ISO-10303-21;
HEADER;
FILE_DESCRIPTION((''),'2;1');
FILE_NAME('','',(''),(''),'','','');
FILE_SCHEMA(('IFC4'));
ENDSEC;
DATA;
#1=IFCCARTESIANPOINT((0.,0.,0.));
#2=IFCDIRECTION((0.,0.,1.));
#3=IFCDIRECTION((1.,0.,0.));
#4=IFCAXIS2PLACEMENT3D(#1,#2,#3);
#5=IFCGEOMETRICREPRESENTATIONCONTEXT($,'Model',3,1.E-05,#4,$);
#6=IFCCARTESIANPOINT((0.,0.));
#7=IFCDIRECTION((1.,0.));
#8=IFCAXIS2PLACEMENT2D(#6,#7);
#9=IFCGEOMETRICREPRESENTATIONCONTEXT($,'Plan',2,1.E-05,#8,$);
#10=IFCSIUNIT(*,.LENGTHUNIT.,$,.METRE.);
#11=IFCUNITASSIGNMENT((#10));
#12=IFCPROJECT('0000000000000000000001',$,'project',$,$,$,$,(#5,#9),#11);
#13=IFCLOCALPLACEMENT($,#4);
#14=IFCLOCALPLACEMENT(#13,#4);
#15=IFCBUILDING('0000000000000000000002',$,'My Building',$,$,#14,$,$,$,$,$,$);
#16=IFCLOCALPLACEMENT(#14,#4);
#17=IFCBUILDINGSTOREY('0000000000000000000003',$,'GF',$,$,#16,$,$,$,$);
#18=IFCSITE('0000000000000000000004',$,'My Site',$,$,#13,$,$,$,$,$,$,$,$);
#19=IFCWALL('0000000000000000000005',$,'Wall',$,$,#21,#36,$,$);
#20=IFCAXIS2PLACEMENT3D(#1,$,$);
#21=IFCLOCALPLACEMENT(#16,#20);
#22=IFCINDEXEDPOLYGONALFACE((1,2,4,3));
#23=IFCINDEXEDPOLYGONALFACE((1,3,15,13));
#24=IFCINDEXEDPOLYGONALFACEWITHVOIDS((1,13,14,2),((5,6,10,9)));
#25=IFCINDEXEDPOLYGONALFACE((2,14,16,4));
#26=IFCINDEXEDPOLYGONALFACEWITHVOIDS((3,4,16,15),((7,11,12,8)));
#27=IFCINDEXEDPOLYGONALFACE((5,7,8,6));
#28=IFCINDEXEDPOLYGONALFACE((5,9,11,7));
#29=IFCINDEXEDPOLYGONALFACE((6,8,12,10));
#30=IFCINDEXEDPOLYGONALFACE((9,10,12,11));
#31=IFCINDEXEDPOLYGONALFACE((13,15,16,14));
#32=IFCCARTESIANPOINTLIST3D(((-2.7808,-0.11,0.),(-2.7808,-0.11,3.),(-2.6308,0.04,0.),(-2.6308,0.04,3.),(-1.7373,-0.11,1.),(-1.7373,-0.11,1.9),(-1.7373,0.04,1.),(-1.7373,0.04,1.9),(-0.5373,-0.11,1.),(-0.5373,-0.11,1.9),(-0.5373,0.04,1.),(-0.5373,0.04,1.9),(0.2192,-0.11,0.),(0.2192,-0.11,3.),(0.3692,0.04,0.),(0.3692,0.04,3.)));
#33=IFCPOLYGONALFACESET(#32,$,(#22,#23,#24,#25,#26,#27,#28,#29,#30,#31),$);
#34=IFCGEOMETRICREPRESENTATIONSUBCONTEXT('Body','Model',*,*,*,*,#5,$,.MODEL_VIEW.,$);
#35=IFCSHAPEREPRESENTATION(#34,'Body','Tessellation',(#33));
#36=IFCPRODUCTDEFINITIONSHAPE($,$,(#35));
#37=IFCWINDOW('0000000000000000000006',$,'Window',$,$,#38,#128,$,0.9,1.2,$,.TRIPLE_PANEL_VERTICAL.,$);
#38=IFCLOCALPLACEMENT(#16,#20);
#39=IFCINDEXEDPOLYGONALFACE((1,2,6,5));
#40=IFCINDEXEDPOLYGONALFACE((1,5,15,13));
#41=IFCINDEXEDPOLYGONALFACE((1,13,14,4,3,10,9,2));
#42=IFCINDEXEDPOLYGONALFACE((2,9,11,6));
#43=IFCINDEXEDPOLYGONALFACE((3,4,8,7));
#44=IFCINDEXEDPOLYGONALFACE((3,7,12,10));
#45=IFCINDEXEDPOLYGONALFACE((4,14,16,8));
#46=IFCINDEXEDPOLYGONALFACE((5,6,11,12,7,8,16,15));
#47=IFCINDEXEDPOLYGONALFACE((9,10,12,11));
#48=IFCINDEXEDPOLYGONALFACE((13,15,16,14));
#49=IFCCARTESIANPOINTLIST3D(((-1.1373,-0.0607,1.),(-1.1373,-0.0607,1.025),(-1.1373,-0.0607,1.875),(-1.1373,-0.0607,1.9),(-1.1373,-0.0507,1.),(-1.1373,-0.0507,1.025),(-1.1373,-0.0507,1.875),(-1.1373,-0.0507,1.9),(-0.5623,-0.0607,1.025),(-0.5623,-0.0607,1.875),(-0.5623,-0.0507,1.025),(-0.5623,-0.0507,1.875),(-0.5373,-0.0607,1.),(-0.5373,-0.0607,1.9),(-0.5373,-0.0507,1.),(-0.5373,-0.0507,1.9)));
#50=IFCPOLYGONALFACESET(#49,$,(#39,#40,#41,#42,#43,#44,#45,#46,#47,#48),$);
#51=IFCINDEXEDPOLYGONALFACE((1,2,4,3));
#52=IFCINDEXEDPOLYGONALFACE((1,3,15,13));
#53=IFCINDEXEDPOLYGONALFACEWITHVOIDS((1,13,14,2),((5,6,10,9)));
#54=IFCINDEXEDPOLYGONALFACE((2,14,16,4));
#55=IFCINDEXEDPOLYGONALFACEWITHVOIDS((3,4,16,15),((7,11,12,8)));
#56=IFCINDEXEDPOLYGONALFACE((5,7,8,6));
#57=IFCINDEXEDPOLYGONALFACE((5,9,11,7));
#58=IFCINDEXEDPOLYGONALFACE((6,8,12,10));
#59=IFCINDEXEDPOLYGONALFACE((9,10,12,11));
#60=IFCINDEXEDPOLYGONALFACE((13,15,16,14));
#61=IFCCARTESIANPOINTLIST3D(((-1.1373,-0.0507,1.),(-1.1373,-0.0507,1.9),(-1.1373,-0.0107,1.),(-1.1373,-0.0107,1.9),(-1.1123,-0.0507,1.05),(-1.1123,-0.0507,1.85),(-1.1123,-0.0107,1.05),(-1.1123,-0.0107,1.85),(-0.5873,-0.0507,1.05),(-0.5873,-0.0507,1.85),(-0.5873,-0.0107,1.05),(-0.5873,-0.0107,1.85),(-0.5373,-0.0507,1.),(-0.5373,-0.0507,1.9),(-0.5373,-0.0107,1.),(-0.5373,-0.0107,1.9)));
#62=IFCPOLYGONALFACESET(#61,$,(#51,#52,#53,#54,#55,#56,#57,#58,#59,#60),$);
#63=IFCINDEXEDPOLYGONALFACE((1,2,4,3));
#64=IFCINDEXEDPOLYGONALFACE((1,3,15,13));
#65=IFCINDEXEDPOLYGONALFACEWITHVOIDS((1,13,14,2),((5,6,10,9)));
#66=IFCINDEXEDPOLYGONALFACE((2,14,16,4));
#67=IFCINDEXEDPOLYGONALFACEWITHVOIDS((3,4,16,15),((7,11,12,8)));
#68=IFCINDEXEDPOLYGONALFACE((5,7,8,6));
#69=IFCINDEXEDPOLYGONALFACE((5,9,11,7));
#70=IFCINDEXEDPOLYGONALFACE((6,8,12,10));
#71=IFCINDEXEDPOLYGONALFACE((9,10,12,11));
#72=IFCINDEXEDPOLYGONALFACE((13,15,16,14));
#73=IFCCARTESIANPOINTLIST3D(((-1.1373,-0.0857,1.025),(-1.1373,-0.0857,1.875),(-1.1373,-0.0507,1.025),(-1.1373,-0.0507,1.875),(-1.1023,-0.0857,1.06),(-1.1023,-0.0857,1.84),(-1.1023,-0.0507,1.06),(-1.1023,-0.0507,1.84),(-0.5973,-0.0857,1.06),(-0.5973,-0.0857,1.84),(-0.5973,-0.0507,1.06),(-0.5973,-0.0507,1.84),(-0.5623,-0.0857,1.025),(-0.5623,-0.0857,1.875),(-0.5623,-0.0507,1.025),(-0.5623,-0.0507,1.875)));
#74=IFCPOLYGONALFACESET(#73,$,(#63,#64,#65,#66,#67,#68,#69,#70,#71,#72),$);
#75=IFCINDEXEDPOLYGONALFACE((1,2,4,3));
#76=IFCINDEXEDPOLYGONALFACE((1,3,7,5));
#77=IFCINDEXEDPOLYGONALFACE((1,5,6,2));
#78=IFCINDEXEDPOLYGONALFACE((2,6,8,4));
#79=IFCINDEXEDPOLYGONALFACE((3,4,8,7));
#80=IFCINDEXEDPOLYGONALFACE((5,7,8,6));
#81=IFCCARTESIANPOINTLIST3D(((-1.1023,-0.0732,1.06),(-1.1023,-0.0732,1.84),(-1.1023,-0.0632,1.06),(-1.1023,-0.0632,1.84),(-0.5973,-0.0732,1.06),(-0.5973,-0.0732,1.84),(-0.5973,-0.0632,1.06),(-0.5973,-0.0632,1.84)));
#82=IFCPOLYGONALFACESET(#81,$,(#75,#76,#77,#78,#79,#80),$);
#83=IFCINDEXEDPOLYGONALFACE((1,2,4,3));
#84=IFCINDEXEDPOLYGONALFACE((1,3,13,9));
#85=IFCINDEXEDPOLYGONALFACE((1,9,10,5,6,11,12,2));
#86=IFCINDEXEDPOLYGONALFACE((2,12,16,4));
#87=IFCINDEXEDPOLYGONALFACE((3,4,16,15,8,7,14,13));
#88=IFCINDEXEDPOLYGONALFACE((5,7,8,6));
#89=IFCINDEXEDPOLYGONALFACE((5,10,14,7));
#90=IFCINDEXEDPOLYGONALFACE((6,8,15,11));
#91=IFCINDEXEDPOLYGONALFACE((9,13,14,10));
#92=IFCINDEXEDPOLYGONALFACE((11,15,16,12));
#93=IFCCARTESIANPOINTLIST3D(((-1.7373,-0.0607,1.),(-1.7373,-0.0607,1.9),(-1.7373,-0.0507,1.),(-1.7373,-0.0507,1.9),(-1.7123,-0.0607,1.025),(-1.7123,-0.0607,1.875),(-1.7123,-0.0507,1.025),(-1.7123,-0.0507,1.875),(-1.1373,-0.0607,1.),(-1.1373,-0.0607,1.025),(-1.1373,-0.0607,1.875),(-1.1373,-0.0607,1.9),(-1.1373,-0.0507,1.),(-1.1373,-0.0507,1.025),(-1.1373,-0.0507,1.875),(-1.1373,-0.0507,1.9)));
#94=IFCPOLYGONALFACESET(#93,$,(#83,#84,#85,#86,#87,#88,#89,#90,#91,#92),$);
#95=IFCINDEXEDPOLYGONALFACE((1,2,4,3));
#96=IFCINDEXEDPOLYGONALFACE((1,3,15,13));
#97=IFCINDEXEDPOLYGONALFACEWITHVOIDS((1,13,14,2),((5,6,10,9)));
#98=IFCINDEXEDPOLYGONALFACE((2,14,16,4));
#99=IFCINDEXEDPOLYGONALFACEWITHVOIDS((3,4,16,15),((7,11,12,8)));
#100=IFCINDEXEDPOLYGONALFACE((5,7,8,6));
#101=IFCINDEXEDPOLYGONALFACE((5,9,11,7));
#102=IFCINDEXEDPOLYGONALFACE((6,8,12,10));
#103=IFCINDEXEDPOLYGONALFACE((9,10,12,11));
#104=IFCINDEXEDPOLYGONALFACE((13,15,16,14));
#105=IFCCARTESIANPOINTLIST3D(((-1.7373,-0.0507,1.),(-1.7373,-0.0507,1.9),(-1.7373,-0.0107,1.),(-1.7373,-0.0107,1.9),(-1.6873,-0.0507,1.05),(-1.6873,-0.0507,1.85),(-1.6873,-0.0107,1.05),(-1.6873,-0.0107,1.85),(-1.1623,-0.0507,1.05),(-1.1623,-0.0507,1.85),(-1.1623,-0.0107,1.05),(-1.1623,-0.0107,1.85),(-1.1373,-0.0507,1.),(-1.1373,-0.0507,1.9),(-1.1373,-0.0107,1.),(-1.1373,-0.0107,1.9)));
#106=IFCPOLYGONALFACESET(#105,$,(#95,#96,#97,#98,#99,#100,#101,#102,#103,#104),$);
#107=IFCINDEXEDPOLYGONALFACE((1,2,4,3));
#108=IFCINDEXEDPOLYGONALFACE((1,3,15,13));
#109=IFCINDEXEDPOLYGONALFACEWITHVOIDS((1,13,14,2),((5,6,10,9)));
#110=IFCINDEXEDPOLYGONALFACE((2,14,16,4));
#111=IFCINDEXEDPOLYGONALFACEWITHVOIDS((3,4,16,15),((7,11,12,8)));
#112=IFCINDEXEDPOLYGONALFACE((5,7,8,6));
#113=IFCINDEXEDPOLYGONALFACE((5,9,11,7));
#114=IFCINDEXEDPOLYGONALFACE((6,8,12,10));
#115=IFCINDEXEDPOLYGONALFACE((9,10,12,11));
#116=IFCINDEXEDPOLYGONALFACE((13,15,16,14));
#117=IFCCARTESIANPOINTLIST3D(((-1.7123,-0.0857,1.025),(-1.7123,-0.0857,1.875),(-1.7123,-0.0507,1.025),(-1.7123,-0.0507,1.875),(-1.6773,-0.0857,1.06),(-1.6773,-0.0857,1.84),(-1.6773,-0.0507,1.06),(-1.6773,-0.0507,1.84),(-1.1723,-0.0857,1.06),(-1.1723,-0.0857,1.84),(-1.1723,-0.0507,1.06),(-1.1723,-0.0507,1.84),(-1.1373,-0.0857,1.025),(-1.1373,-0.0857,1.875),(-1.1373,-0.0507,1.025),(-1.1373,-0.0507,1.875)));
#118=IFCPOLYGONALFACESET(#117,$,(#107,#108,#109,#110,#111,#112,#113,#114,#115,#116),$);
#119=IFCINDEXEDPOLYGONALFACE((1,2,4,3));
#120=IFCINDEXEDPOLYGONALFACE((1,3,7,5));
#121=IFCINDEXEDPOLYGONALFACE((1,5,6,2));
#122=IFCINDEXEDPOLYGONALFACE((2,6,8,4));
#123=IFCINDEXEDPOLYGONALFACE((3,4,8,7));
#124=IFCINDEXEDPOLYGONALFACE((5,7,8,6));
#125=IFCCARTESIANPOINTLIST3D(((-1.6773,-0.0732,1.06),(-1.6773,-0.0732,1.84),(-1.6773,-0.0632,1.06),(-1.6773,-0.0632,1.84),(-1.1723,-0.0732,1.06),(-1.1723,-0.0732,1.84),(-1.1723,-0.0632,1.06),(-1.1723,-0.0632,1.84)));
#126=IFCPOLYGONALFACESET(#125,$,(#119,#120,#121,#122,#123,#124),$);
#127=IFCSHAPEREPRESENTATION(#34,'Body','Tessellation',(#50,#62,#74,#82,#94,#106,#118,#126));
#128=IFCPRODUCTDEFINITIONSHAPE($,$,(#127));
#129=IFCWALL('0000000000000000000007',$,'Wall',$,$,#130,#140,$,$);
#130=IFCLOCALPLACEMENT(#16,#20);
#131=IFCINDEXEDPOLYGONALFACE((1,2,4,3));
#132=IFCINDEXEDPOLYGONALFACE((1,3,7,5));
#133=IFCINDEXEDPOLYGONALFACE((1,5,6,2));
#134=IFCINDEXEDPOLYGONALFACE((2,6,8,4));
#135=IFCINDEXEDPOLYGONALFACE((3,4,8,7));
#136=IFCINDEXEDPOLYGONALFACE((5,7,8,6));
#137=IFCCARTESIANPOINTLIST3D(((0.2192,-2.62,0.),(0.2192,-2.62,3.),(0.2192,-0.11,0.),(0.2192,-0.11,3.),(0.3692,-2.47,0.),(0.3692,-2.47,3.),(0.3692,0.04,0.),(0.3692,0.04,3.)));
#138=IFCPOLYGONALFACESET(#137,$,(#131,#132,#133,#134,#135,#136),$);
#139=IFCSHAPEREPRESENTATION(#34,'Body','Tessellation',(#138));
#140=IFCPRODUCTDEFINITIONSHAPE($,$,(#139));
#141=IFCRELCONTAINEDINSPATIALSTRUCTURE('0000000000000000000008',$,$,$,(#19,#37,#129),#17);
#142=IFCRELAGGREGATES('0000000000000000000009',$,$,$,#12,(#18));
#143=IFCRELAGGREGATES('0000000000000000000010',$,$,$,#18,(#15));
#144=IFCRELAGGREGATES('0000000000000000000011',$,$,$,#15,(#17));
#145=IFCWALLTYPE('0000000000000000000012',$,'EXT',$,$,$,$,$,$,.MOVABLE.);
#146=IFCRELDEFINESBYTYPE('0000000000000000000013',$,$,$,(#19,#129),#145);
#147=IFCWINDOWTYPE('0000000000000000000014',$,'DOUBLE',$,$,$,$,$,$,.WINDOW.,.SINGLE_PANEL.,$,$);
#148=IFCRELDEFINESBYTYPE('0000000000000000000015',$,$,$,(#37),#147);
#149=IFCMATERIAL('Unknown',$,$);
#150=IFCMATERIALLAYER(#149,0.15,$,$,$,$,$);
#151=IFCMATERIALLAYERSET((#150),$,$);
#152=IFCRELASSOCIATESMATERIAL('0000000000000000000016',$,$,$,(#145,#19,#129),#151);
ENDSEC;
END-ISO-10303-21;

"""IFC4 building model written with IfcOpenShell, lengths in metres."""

from ifc_helpers import new_model, entity, si_unit, frame, origin_with_axes, origin_2d_with_axis, place, context, subcontext, project, spatial, line, indexed_curve, outline, extrude, shape, source, transform, mapped, material, layer, layer_set, layer_usage, type_object, type_shapes, element, fill, save


model = new_model("IFC4")

# Units and contexts
model_context = context("Model", 3, precision=1e-05, world=origin_with_axes())
plan_context = context("Plan", 2, precision=1e-05, world=origin_2d_with_axis())
body_context_1 = subcontext(model_context, "Body", "Model", "MODEL_VIEW")
body_context_2 = subcontext(plan_context, "Body", "Plan", "PLAN_VIEW")
ifc_project = project(units=[si_unit("LENGTHUNIT", "METRE")], contexts=[model_context, plan_context])

# Site, building, storey
site_placement = place(None, origin_with_axes())
site = spatial("IfcSite", under=ifc_project, at=site_placement, Name="My Site")
building_placement = place(site_placement, origin_with_axes())
building = spatial("IfcBuilding", under=site, at=building_placement, Name="My Building")
storey_placement = place(building_placement, origin_with_axes())
storey = spatial("IfcBuildingStorey", under=building, at=storey_placement, Name="GF")

# Shared definitions
ifc_material = material(Name="Unknown")

# Shared definitions
ifc_layer_1 = layer(ifc_material, 0.15)
ifc_layer_set_1 = layer_set([ifc_layer_1])
wall_type_1 = type_object("IfcWallType", Name="EXT", PredefinedType="MOVABLE", material=ifc_layer_set_1)

# Wall, opening, window
ifc_layer_usage_1 = layer_usage(ifc_layer_set_1, "AXIS2", "POSITIVE", 0.0)
wall_1_placement = place(storey_placement, frame((-2.7808, -0.11, 0.0), z_axis=(0.0, 0.0, 1.0), x_axis=(1.0, 0.0, 0.0)))
wall_1 = element("IfcWall", 1, at=wall_1_placement, inside=storey, type_object=wall_type_1, material=ifc_layer_usage_1, Name="Wall", context=body_context_1, shape_type="SweptSolid", body=[
    extrude(outline(indexed_curve([(0.0, 0.0), (0.15, 0.15), (3.15, 0.15), (3.0, 0.0)], segments=[line(1, 2, 3, 4, 1)])), origin_with_axes(), (0.0, 0.0, 1.0), 3.0),
])
placement_1 = place(storey_placement, frame((-0.5373, 0.0393, 1.0), z_axis=(0.0, 0.0, 1.0), x_axis=(-1.0, 0.000001, 0.0)))
opening_1 = element("IfcOpeningElement", 2, at=placement_1, cuts=wall_1, PredefinedType="OPENING", context=body_context_1, shape_type="SweptSolid", body=[
    extrude(outline(indexed_curve([(0.0, 0.0), (1.2, 0.0), (1.2, 0.9), (0.0, 0.9)], segments=[line(1, 2, 3, 4, 1)])), frame((0.0, -0.6, 0.0), z_axis=(0.0, -1.0, 0.0), x_axis=(1.0, 0.0, 0.0)), (0.0, 0.0, -1.0), 1.2),
])
window_type_1 = type_object("IfcWindowType", Name="DOUBLE", PartitioningType="SINGLE_PANEL", PredefinedType="WINDOW")
shared_shape_1 = source(origin_with_axes(), body_context_1, "Body", "SweptSolid", [
    extrude(outline(indexed_curve([(0.6, 0.0), (0.0, 0.0), (0.0, 0.9), (0.6, 0.9), (0.6, 0.875), (0.025, 0.875), (0.025, 0.025), (0.6, 0.025)], segments=[line(1, 2, 3, 4, 5, 6, 7, 8, 1)])), frame((0.0, 0.09, 0.0), z_axis=(0.0, -1.0, 0.0), x_axis=(1.0, 0.0, 0.0)), (0.0, 0.0, -1.0), 0.01),
    extrude(outline(indexed_curve([(0.0, 0.0), (0.6, 0.0), (0.6, 0.9), (0.0, 0.9)], segments=[line(1, 2, 3, 4, 1)]), holes=[indexed_curve([(0.05, 0.05), (0.575, 0.05), (0.575, 0.85), (0.05, 0.85)], segments=[line(1, 2, 3, 4, 1)])]), frame((0.0, 0.05, 0.0), z_axis=(0.0, -1.0, 0.0), x_axis=(1.0, 0.0, 0.0)), (0.0, 0.0, -1.0), 0.04),
    extrude(outline(indexed_curve([(0.0, 0.0), (0.575, 0.0), (0.575, 0.85), (0.0, 0.85)], segments=[line(1, 2, 3, 4, 1)]), holes=[indexed_curve([(0.035, 0.035), (0.54, 0.035), (0.54, 0.815), (0.035, 0.815)], segments=[line(1, 2, 3, 4, 1)])]), frame((0.025, 0.09, 0.025), z_axis=(0.0, -1.0, 0.0), x_axis=(1.0, 0.0, 0.0)), (0.0, 0.0, -1.0), 0.035),
    extrude(outline(indexed_curve([(0.035, 0.035), (0.54, 0.035), (0.54, 0.815), (0.035, 0.815)], segments=[line(1, 2, 3, 4, 1)])), frame((0.025, 0.1025, 0.025), z_axis=(0.0, -1.0, 0.0), x_axis=(1.0, 0.0, 0.0)), (0.0, 0.0, -1.0), 0.01),
    extrude(outline(indexed_curve([(0.0, 0.9), (0.6, 0.9), (0.6, 0.0), (0.0, 0.0), (0.0, 0.025), (0.575, 0.025), (0.575, 0.875), (0.0, 0.875)], segments=[line(1, 2, 3, 4, 5, 6, 7, 8, 1)])), frame((0.6, 0.09, 0.0), z_axis=(0.0, -1.0, 0.0), x_axis=(1.0, 0.0, 0.0)), (0.0, 0.0, -1.0), 0.01),
    extrude(outline(indexed_curve([(0.0, 0.0), (0.6, 0.0), (0.6, 0.9), (0.0, 0.9)], segments=[line(1, 2, 3, 4, 1)]), holes=[indexed_curve([(0.025, 0.05), (0.55, 0.05), (0.55, 0.85), (0.025, 0.85)], segments=[line(1, 2, 3, 4, 1)])]), frame((0.6, 0.05, 0.0), z_axis=(0.0, -1.0, 0.0), x_axis=(1.0, 0.0, 0.0)), (0.0, 0.0, -1.0), 0.04),
    extrude(outline(indexed_curve([(0.0, 0.0), (0.575, 0.0), (0.575, 0.85), (0.0, 0.85)], segments=[line(1, 2, 3, 4, 1)]), holes=[indexed_curve([(0.035, 0.035), (0.54, 0.035), (0.54, 0.815), (0.035, 0.815)], segments=[line(1, 2, 3, 4, 1)])]), frame((0.6, 0.09, 0.025), z_axis=(0.0, -1.0, 0.0), x_axis=(1.0, 0.0, 0.0)), (0.0, 0.0, -1.0), 0.035),
    extrude(outline(indexed_curve([(0.035, 0.815), (0.54, 0.815), (0.54, 0.035), (0.035, 0.035), (0.035, 0.815)])), frame((0.6, 0.1025, 0.025), z_axis=(0.0, -1.0, 0.0), x_axis=(1.0, 0.0, 0.0)), (0.0, 0.0, -1.0), 0.01),
])
shared_shape_2 = source(origin_with_axes(), body_context_2, "Body", "Curve2D", [
    entity("IfcIndexedPolyCurve", entity("IfcCartesianPointList2D", [[0.05, 0.05], [0.575, 0.05]])),
    entity("IfcIndexedPolyCurve", entity("IfcCartesianPointList2D", [[0.0, 0.1], [0.025, 0.1], [0.025, 0.09], [0.05, 0.09], [0.05, 0.05], [0.0, 0.05]]), [entity("IfcLineIndex", [1, 2, 3, 4, 5, 6, 1])]),
    entity("IfcIndexedPolyCurve", entity("IfcCartesianPointList2D", [[0.6, 0.1], [0.6, 0.1], [0.6, 0.09], [0.575, 0.09], [0.575, 0.05], [0.6, 0.05]])),
    entity("IfcIndexedPolyCurve", entity("IfcCartesianPointList2D", [[0.025, 0.09], [0.06, 0.09], [0.06, 0.125], [0.025, 0.125]]), [entity("IfcLineIndex", [1, 2, 3, 4, 1])]),
    entity("IfcIndexedPolyCurve", entity("IfcCartesianPointList2D", [[0.6, 0.09], [0.565, 0.09], [0.565, 0.125], [0.6, 0.125]]), [entity("IfcLineIndex", [1, 2, 3, 4, 1])]),
    entity("IfcIndexedPolyCurve", entity("IfcCartesianPointList2D", [[0.06, 0.09], [0.565, 0.09]])),
    entity("IfcIndexedPolyCurve", entity("IfcCartesianPointList2D", [[0.06, 0.125], [0.565, 0.125]])),
    entity("IfcIndexedPolyCurve", entity("IfcCartesianPointList2D", [[0.06, 0.1075], [0.565, 0.1075]])),
    entity("IfcIndexedPolyCurve", entity("IfcCartesianPointList2D", [[0.625, 0.05], [1.15, 0.05]])),
    entity("IfcIndexedPolyCurve", entity("IfcCartesianPointList2D", [[0.6, 0.1], [0.6, 0.1], [0.6, 0.09], [0.625, 0.09], [0.625, 0.05], [0.6, 0.05]])),
    entity("IfcIndexedPolyCurve", entity("IfcCartesianPointList2D", [[1.2, 0.1], [1.175, 0.1], [1.175, 0.09], [1.15, 0.09], [1.15, 0.05], [1.2, 0.05]]), [entity("IfcLineIndex", [1, 2, 3, 4, 5, 6, 1])]),
    entity("IfcIndexedPolyCurve", entity("IfcCartesianPointList2D", [[0.6, 0.09], [0.635, 0.09], [0.635, 0.125], [0.6, 0.125]]), [entity("IfcLineIndex", [1, 2, 3, 4, 1])]),
    entity("IfcIndexedPolyCurve", entity("IfcCartesianPointList2D", [[1.175, 0.09], [1.14, 0.09], [1.14, 0.125], [1.175, 0.125]]), [entity("IfcLineIndex", [1, 2, 3, 4, 1])]),
    entity("IfcIndexedPolyCurve", entity("IfcCartesianPointList2D", [[0.635, 0.09], [1.14, 0.09]])),
    entity("IfcIndexedPolyCurve", entity("IfcCartesianPointList2D", [[0.635, 0.125], [1.14, 0.125]])),
    entity("IfcIndexedPolyCurve", entity("IfcCartesianPointList2D", [[0.635, 0.1075], [1.14, 0.1075]])),
])
type_shapes(window_type_1, [shared_shape_1, shared_shape_2])
window_1 = element("IfcWindow", 3, at=placement_1, inside=storey, type_object=window_type_1, Name="Window", OverallHeight=0.9, OverallWidth=1.2, PartitioningType="TRIPLE_PANEL_VERTICAL", shapes=[
    shape(body_context_1, "Body", "MappedRepresentation", [mapped(shared_shape_1, transform((0.0, 0.0, 0.0), x_axis=(1.0, 0.0, 0.0), y_axis=(0.0, 1.0, 0.0), z_axis=(0.0, 0.0, 1.0), scale=1.0))]),
    shape(body_context_2, "Body", "MappedRepresentation", [mapped(shared_shape_2, transform((0.0, 0.0, 0.0), x_axis=(1.0, 0.0, 0.0), y_axis=(0.0, 1.0, 0.0), z_axis=(0.0, 0.0, 1.0), scale=1.0))]),
])
fill(opening_1, window_1)

# Wall
ifc_layer_usage_2 = layer_usage(ifc_layer_set_1, "AXIS2", "POSITIVE", 0.0)
wall_2_placement = place(storey_placement, frame((0.2192, -0.11, 0.0), z_axis=(0.0, 0.0, 1.0), x_axis=(0.0, -1.0, 0.0)))
element("IfcWall", 4, at=wall_2_placement, inside=storey, type_object=wall_type_1, material=ifc_layer_usage_2, Name="Wall", context=body_context_1, shape_type="SweptSolid", body=[
    extrude(outline(indexed_curve([(0.0, 0.0), (-0.15, 0.15), (2.36, 0.15), (2.51, 0.0)], segments=[line(1, 2, 3, 4, 1)])), origin_with_axes(), (0.0, 0.0, 1.0), 3.0),
])

save(model, "model.ifc")
